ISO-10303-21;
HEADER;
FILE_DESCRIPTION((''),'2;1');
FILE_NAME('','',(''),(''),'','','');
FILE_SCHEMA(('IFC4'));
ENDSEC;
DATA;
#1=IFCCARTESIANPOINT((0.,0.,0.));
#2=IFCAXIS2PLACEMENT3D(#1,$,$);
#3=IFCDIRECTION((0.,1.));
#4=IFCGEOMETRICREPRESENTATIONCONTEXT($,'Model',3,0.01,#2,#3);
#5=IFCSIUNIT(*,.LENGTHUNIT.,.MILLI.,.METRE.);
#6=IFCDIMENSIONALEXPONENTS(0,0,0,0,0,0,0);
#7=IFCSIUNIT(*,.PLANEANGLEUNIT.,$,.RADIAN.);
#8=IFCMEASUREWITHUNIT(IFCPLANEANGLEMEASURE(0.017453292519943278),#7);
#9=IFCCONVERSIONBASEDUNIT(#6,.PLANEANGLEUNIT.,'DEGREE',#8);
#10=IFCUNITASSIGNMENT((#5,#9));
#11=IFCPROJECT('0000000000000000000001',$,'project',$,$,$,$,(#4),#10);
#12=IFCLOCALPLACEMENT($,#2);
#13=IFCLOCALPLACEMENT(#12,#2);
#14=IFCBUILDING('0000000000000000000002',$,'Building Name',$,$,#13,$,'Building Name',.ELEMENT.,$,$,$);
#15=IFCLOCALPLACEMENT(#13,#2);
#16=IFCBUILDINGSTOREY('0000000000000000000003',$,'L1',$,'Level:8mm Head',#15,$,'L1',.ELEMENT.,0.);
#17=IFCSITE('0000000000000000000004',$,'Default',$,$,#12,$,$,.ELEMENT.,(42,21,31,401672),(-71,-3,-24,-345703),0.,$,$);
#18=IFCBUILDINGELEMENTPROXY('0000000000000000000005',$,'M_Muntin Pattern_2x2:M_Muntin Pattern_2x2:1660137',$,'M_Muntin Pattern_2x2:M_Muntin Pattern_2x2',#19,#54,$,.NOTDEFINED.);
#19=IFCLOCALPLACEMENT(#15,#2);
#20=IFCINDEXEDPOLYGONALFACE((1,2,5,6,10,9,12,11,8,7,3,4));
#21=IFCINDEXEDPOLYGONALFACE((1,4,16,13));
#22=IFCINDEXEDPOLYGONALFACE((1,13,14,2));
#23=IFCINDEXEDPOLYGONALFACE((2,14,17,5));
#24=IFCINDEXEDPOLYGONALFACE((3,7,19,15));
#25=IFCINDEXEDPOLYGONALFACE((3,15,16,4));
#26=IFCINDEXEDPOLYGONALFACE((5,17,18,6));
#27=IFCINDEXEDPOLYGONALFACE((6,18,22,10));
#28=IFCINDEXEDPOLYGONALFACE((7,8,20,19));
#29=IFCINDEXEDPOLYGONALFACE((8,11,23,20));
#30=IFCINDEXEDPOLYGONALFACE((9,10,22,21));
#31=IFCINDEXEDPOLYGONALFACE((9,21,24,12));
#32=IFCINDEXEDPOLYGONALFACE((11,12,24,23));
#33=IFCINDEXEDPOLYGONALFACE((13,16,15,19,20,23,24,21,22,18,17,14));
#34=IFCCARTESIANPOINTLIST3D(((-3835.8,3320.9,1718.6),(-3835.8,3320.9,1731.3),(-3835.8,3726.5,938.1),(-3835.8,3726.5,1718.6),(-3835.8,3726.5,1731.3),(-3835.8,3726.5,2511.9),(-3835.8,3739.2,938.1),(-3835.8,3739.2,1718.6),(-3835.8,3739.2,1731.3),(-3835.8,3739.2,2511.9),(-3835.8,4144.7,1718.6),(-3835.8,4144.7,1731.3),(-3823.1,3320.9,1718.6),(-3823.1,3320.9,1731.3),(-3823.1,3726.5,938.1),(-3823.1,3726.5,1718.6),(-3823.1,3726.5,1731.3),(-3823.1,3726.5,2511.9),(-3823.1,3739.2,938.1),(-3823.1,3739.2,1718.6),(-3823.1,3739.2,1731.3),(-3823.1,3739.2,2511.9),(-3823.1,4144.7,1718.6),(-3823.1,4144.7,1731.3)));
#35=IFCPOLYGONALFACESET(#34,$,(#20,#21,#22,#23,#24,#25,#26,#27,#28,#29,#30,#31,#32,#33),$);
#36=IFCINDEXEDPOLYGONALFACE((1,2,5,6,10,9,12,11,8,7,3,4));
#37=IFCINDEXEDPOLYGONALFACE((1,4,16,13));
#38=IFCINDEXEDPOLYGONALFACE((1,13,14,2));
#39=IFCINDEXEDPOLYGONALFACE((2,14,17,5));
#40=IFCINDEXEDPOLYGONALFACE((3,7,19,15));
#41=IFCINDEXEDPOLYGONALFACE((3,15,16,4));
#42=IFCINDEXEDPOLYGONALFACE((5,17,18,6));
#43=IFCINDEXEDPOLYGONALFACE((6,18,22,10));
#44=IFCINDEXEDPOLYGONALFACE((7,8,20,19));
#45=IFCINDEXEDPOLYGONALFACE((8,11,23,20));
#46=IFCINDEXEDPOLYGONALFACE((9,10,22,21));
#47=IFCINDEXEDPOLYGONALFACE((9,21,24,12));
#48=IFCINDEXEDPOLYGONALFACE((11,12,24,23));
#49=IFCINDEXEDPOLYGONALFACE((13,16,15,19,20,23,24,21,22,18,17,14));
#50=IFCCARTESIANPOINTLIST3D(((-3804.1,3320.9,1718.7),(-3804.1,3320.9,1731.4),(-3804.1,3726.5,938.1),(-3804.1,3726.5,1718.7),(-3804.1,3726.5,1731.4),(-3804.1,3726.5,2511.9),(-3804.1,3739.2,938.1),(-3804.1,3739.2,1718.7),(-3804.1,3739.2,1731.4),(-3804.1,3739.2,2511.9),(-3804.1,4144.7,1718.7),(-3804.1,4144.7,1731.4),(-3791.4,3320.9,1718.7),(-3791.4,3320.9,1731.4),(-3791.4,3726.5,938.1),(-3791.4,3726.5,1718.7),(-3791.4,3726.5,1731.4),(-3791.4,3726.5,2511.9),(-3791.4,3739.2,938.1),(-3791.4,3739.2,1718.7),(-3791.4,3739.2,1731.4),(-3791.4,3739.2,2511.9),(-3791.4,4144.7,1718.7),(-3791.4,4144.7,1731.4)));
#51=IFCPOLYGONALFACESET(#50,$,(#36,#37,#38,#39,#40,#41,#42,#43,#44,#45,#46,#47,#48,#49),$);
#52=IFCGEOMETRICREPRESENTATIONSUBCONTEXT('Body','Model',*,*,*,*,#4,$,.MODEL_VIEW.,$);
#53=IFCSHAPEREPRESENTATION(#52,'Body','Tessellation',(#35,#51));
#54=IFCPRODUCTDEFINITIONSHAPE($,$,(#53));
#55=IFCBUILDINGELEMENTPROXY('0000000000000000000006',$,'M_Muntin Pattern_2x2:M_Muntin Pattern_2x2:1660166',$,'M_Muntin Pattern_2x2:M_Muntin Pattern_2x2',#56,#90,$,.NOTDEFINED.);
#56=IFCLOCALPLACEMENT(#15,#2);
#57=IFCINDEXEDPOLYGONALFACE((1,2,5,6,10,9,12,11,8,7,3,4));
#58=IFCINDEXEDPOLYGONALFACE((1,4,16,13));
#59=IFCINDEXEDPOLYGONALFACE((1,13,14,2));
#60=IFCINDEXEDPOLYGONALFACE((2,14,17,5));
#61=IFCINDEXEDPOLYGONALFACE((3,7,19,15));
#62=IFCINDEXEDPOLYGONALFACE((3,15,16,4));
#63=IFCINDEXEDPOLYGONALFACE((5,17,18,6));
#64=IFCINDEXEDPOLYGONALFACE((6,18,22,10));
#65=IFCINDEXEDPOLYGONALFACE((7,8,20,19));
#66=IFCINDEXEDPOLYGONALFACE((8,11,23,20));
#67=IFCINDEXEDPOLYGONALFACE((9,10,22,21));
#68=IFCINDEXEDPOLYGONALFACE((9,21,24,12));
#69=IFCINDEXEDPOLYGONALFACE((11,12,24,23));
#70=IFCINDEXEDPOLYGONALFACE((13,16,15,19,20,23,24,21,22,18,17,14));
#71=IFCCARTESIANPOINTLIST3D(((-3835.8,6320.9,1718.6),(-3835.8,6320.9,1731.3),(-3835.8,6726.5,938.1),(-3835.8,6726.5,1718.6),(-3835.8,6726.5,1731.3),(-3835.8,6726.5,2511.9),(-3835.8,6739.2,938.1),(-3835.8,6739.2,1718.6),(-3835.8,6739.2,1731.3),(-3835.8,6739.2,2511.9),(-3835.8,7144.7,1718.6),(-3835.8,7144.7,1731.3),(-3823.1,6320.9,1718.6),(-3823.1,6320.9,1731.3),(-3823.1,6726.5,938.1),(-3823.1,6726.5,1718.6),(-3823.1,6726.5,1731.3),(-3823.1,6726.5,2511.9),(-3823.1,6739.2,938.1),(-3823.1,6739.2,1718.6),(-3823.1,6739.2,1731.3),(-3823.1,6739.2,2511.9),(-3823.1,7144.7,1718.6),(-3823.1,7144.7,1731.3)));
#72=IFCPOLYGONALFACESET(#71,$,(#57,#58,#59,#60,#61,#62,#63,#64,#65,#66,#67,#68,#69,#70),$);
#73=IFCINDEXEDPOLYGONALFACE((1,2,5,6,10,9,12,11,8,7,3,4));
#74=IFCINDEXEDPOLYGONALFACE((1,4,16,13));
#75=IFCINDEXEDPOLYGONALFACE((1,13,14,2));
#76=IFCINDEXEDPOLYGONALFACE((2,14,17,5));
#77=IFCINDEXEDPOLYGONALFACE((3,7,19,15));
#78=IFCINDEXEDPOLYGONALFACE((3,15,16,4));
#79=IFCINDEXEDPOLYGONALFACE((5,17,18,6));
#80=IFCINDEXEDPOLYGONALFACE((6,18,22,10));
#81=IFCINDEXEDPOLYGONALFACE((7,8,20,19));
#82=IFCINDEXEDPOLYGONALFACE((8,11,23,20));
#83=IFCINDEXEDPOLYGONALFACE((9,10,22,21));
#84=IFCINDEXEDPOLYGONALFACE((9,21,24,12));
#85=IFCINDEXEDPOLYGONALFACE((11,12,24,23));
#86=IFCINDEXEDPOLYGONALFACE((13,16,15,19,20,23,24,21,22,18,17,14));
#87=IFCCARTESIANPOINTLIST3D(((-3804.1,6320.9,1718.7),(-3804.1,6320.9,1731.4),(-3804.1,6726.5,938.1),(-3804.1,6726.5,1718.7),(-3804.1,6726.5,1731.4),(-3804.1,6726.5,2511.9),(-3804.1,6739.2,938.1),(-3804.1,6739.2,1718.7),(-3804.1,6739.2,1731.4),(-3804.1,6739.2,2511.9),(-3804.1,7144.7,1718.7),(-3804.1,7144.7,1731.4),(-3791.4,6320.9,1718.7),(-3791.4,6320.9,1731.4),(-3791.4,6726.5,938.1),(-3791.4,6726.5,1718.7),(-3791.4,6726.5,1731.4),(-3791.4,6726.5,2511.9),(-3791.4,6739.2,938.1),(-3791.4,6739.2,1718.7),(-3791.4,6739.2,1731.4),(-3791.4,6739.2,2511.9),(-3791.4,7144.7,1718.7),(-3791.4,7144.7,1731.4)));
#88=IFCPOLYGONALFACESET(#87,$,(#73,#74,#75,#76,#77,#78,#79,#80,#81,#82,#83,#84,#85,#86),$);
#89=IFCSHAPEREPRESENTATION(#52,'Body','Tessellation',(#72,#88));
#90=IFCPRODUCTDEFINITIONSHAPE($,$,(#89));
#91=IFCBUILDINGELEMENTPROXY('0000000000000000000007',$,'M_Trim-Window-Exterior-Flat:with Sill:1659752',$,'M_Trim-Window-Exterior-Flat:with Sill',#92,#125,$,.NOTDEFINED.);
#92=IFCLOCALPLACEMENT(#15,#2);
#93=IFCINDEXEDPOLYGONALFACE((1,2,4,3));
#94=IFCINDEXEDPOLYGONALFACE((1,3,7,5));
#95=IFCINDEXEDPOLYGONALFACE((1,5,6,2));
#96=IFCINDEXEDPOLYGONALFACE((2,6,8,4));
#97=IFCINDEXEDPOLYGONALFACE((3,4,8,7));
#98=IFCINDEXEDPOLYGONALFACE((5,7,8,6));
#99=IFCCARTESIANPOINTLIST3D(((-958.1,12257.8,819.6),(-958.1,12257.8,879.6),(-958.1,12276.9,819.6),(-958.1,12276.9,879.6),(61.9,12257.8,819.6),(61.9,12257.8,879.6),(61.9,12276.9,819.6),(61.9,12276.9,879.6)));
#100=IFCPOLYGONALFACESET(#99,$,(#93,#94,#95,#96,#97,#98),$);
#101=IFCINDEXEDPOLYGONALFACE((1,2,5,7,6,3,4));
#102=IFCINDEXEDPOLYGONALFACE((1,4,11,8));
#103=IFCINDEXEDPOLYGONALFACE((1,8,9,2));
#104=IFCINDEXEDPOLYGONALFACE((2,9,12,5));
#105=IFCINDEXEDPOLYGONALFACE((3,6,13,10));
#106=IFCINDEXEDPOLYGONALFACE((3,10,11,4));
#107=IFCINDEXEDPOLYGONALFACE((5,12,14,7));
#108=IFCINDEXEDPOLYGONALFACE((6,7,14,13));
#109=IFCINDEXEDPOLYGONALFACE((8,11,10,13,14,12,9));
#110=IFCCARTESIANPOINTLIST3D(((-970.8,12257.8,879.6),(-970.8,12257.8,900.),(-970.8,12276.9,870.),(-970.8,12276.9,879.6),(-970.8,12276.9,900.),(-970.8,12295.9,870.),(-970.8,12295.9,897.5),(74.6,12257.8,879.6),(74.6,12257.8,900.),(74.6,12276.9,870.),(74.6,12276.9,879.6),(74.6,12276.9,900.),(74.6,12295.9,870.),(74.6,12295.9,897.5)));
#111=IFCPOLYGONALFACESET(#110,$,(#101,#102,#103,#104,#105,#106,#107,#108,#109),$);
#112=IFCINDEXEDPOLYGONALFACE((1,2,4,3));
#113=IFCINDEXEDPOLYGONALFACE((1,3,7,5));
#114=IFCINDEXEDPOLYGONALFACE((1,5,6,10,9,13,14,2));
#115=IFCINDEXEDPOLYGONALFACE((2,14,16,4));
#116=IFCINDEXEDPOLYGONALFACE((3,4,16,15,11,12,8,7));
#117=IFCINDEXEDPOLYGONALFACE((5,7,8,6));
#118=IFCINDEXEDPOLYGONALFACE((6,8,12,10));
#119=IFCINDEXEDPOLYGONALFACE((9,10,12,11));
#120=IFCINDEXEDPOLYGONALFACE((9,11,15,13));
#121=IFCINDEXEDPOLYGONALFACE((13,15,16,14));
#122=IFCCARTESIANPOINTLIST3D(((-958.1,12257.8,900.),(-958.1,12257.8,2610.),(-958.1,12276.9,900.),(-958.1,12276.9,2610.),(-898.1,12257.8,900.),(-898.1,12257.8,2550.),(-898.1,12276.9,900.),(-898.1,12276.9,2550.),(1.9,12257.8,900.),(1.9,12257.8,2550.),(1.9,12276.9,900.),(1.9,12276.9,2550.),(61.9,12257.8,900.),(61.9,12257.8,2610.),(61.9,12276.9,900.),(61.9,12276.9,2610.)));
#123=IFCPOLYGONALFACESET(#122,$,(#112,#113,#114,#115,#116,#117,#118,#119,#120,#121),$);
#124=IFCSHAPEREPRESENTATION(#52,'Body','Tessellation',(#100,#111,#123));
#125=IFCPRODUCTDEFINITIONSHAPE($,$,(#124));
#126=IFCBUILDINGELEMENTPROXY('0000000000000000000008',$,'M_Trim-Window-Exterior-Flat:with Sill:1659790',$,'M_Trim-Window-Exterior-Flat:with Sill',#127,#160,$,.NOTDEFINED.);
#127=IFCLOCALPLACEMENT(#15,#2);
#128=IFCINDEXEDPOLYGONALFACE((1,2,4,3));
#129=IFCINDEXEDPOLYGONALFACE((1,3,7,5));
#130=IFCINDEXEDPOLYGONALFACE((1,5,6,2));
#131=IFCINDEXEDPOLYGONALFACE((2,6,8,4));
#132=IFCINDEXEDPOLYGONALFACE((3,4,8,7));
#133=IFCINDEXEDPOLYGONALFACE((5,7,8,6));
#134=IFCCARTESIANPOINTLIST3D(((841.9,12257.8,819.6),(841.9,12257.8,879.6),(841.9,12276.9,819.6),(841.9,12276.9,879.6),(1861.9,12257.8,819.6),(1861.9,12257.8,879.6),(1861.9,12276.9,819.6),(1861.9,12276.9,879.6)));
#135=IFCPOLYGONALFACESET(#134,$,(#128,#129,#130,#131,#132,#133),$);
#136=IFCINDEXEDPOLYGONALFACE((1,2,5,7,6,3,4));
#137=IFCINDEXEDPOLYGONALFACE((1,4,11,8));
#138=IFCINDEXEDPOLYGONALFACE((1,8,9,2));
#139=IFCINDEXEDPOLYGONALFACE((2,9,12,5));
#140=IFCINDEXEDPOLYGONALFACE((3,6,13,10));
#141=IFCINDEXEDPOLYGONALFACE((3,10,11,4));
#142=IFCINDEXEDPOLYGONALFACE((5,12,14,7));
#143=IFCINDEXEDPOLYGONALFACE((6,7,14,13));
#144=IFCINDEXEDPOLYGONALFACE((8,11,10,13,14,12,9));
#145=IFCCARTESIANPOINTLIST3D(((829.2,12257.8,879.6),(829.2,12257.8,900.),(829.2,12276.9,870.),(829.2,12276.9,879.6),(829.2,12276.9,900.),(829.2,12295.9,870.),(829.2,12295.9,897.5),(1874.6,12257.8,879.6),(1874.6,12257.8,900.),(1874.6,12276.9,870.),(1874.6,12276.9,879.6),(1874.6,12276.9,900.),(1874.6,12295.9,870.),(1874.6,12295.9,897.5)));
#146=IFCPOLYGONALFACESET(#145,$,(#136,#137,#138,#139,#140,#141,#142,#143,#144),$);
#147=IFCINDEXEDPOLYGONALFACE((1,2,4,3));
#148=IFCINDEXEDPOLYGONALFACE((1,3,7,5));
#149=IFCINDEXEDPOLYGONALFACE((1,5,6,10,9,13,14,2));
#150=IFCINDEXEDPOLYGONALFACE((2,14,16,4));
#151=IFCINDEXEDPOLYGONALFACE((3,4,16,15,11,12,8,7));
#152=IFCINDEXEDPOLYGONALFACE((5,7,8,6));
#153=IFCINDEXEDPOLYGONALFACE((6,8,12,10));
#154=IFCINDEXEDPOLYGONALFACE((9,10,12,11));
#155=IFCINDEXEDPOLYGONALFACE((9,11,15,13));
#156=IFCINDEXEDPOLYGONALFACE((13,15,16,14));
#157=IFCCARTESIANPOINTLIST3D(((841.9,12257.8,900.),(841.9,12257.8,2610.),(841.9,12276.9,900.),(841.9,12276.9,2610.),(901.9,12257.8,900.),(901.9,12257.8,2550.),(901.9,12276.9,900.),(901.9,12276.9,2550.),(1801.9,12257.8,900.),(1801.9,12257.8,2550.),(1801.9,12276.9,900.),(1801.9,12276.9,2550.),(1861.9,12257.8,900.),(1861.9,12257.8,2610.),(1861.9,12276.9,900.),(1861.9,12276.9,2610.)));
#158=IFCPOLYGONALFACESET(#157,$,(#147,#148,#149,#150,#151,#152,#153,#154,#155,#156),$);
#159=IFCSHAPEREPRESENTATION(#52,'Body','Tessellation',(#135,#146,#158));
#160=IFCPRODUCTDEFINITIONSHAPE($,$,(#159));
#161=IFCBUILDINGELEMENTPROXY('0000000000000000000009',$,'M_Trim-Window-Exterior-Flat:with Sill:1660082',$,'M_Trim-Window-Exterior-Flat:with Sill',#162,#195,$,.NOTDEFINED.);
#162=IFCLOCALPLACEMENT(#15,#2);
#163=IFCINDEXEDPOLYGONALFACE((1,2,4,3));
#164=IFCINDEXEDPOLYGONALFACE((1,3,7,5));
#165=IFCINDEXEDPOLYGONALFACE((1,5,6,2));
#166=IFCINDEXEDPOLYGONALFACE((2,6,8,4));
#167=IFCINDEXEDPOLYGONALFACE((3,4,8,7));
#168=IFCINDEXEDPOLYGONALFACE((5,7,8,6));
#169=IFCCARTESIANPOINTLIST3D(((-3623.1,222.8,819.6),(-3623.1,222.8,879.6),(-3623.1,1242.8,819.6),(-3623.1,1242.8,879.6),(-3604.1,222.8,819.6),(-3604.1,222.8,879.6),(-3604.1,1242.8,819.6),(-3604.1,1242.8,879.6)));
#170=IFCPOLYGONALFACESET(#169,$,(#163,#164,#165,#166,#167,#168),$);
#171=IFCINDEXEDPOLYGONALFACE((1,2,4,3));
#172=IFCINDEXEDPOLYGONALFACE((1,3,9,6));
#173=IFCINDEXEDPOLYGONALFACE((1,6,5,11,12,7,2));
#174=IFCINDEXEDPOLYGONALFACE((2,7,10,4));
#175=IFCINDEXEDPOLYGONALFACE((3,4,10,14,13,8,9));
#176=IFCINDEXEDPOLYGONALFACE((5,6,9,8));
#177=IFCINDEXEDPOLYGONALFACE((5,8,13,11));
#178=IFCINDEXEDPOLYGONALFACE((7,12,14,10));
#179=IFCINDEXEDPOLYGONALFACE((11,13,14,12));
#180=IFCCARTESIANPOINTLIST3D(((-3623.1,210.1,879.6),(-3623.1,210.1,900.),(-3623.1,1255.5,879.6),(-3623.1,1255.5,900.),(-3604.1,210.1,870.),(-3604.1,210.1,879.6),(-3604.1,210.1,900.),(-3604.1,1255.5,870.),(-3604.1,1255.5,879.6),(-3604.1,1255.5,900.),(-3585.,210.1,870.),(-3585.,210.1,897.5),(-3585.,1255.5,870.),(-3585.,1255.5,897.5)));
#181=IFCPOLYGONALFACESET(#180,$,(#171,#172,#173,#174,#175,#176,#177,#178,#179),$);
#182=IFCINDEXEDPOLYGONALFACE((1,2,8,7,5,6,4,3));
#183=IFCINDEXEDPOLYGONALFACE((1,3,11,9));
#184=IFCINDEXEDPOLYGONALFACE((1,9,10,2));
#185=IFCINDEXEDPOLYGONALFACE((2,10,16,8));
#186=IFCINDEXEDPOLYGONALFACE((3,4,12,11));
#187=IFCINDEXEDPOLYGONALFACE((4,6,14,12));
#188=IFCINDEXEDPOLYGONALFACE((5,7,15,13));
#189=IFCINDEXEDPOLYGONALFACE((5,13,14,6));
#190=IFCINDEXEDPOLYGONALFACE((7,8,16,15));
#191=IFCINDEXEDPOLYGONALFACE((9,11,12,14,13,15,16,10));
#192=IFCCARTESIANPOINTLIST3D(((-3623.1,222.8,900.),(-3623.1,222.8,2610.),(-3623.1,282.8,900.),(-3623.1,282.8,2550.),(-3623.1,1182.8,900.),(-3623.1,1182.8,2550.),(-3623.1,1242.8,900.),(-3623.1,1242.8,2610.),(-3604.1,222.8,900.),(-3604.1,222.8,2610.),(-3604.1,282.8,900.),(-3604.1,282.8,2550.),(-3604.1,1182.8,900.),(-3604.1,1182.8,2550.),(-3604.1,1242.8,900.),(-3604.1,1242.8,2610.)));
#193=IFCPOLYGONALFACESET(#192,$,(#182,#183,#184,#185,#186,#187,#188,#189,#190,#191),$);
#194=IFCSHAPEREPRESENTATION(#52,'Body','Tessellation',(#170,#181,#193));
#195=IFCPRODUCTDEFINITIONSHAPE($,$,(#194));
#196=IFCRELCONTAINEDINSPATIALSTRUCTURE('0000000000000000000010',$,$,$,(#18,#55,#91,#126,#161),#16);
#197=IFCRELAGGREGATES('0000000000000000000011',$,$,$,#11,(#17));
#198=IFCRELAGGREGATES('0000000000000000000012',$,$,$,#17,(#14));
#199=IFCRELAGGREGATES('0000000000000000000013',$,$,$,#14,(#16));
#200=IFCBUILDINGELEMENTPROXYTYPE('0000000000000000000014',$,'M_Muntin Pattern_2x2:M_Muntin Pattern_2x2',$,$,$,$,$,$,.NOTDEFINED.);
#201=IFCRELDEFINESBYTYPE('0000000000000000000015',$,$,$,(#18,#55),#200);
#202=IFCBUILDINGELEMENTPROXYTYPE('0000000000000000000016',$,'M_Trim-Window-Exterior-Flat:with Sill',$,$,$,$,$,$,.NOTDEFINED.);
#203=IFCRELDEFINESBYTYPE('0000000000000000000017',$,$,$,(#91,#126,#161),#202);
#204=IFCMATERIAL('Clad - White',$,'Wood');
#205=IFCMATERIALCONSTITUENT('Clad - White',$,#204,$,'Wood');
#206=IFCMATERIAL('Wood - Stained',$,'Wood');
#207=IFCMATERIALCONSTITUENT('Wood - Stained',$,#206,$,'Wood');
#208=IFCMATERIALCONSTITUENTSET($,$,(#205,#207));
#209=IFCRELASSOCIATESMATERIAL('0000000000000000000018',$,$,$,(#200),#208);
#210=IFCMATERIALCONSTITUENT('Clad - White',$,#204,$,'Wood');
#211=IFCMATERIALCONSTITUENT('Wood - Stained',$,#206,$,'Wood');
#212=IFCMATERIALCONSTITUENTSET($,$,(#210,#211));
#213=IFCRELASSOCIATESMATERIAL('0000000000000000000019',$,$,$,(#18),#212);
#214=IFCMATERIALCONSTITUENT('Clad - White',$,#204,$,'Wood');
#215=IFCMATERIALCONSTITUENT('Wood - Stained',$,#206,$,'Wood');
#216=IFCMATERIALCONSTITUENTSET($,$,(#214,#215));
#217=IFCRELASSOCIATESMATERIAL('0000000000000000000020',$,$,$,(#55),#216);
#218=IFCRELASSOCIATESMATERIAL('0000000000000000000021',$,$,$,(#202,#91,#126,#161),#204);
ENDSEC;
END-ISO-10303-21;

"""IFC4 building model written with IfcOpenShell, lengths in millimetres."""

from ifc_helpers import new_model, entity, si_unit, converted_unit, direction, frame, origin, place, context, subcontext, project, spatial, indexed_curve, outline, extrude, source, transform, mapped, material, constituent, constituent_set, type_object, type_shapes, element, save


model = new_model("IFC4")

# Units and contexts
model_context = context("Model", 3, precision=0.01, world=origin(), true_north=direction((0.0, 1.0)))
body_context = subcontext(model_context, "Body", "Model", "MODEL_VIEW")
ifc_project = project(units=[si_unit("LENGTHUNIT", "METRE", prefix="MILLI"), converted_unit("PLANEANGLEUNIT", "DEGREE", entity("IfcPlaneAngleMeasure", 0.017453292519943278), si_unit("PLANEANGLEUNIT", "RADIAN"), dimensions=[0, 0, 0, 0, 0, 0, 0])], contexts=[model_context])

# Site, building, storey
site_placement = place(None, origin())
site = spatial("IfcSite", under=ifc_project, at=site_placement, Name="Default", CompositionType="ELEMENT", RefLatitude=(42, 21, 31, 401672), RefLongitude=(-71, -3, -24, -345703), RefElevation=0.0)
building_placement = place(site_placement, origin())
building = spatial("IfcBuilding", under=site, at=building_placement, Name="Building Name", LongName="Building Name", CompositionType="ELEMENT")
storey_placement = place(building_placement, origin())
storey = spatial("IfcBuildingStorey", under=building, at=storey_placement, Name="L1", ObjectType="Level:8mm Head", LongName="L1", CompositionType="ELEMENT", Elevation=0.0)

# Building element proxies
ifc_material_1 = material(Name="Clad - White", Category="Wood")
ifc_material_2 = material(Name="Wood - Stained", Category="Wood")
ifc_constituent_1 = constituent(ifc_material_1, Name="Clad - White", Category="Wood")
ifc_constituent_2 = constituent(ifc_material_2, Name="Wood - Stained", Category="Wood")
ifc_constituent_set_1 = constituent_set(constituents=[ifc_constituent_1, ifc_constituent_2])
building_element_proxy_type_1 = type_object("IfcBuildingElementProxyType", Name="M_Muntin Pattern_2x2:M_Muntin Pattern_2x2", PredefinedType="NOTDEFINED", material=ifc_constituent_set_1)
shared_shape_1 = source(origin(), body_context, "Body", "SweptSolid", [
    extrude(outline(indexed_curve([(6.4, -6.4), (786.9, -6.4), (786.9, 6.3), (6.4, 6.3), (6.4, 411.9), (-6.3, 411.9), (-6.3, 6.3), (-786.9, 6.3), (-786.9, -6.4), (-6.3, -6.4), (-6.3, -411.9), (6.4, -411.9), (6.4, -6.4)], self_intersect=False)), frame((0.0, -22.2, 786.9), z_axis=(0.0, 1.0, 0.0), x_axis=(0.0, 0.0, 1.0)), (0.0, 0.0, 1.0), 12.7),
    extrude(outline(indexed_curve([(6.4, -6.4), (786.9, -6.4), (786.9, 6.3), (6.4, 6.3), (6.4, 411.9), (-6.3, 411.9), (-6.3, 6.3), (-786.9, 6.3), (-786.9, -6.4), (-6.3, -6.4), (-6.3, -411.9), (6.4, -411.9), (6.4, -6.4)], self_intersect=False)), frame((0.0, 9.5, 786.9), z_axis=(0.0, 1.0, 0.0), x_axis=(0.0, 0.0, 1.0)), (0.0, 0.0, 1.0), 12.7),
])
type_shapes(building_element_proxy_type_1, [shared_shape_1])
ifc_constituent_3 = constituent(ifc_material_1, Name="Clad - White", Category="Wood")
ifc_constituent_4 = constituent(ifc_material_2, Name="Wood - Stained", Category="Wood")
ifc_constituent_set_2 = constituent_set(constituents=[ifc_constituent_3, ifc_constituent_4])
proxy_1_placement = place(storey_placement, frame((-3813.6, 3732.8, 938.1), z_axis=(0.0, 0.0, 1.0), x_axis=(0.0, -1.0, 0.0)))
element("IfcBuildingElementProxy", 1, at=proxy_1_placement, inside=storey, type_object=building_element_proxy_type_1, material=ifc_constituent_set_2, Name="M_Muntin Pattern_2x2:M_Muntin Pattern_2x2:1660137", ObjectType="M_Muntin Pattern_2x2:M_Muntin Pattern_2x2", PredefinedType="NOTDEFINED", context=body_context, shape_type="MappedRepresentation", body=[
    mapped(shared_shape_1, transform((0.0, 0.0, 0.0), scale=1.0)),
])
ifc_constituent_5 = constituent(ifc_material_1, Name="Clad - White", Category="Wood")
ifc_constituent_6 = constituent(ifc_material_2, Name="Wood - Stained", Category="Wood")
ifc_constituent_set_3 = constituent_set(constituents=[ifc_constituent_5, ifc_constituent_6])
proxy_2_placement = place(storey_placement, frame((-3813.6, 6732.8, 938.1), z_axis=(0.0, 0.0, 1.0), x_axis=(0.0, -1.0, 0.0)))
element("IfcBuildingElementProxy", 2, at=proxy_2_placement, inside=storey, type_object=building_element_proxy_type_1, material=ifc_constituent_set_3, Name="M_Muntin Pattern_2x2:M_Muntin Pattern_2x2:1660166", ObjectType="M_Muntin Pattern_2x2:M_Muntin Pattern_2x2", PredefinedType="NOTDEFINED", context=body_context, shape_type="MappedRepresentation", body=[
    mapped(shared_shape_1, transform((0.0, 0.0, 0.0), scale=1.0)),
])
building_element_proxy_type_2 = type_object("IfcBuildingElementProxyType", Name="M_Trim-Window-Exterior-Flat:with Sill", PredefinedType="NOTDEFINED", material=ifc_material_1)
shared_shape_2 = source(origin(), body_context, "Body", "SweptSolid", [
    extrude(outline(indexed_curve([(-510.0, -30.0), (510.0, -30.0), (510.0, 30.0), (-510.0, 30.0), (-510.0, -30.0)], self_intersect=False)), frame((0.0, -1700.4, 0.0), z_axis=(0.0, 0.0, 1.0), x_axis=(-1.0, 0.0, 0.0)), (0.0, 0.0, 1.0), 19.0),
    extrude(outline(indexed_curve([(-19.0, -15.2), (0.0, -15.2), (0.0, -5.7), (19.0, -5.7), (19.0, 14.8), (0.0, 14.8), (-19.0, 12.3), (-19.0, -15.2)], self_intersect=False)), frame((-522.7, -1664.8, 19.0), z_axis=(1.0, 0.0, 0.0), x_axis=(0.0, 0.0, -1.0)), (0.0, 0.0, 1.0), 1045.4),
    extrude(outline(indexed_curve([(-870.0, -510.0), (840.0, -510.0), (840.0, -450.0), (-810.0, -450.0), (-810.0, 450.0), (840.0, 450.0), (840.0, 510.0), (-870.0, 510.0), (-870.0, -510.0)], self_intersect=False)), frame((0.0, -810.0, 0.0), z_axis=(0.0, 0.0, 1.0), x_axis=(0.0, -1.0, 0.0)), (0.0, 0.0, 1.0), 19.0),
])
type_shapes(building_element_proxy_type_2, [shared_shape_2])
for number, where, z_axis, x_axis, name in (
    (3, (-448.1, 12257.8, 2550.0), (0.0, 1.0, 0.0), (-1.0, 0.0, 0.0), "M_Trim-Window-Exterior-Flat:with Sill:1659752"),
    (4, (1351.9, 12257.8, 2550.0), (0.0, 1.0, 0.0), (-1.0, 0.0, 0.0), "M_Trim-Window-Exterior-Flat:with Sill:1659790"),
    (5, (-3623.1, 732.8, 2550.0), (1.0, 0.0, 0.0), (0.0, 1.0, 0.0), "M_Trim-Window-Exterior-Flat:with Sill:1660082"),
):
    element("IfcBuildingElementProxy", number, at=place(storey_placement, frame(where, z_axis=z_axis, x_axis=x_axis)), inside=storey, type_object=building_element_proxy_type_2, material=ifc_material_1, Name=name, ObjectType="M_Trim-Window-Exterior-Flat:with Sill", PredefinedType="NOTDEFINED", context=body_context, shape_type="MappedRepresentation", body=[
        mapped(shared_shape_2, transform((0.0, 0.0, 0.0), scale=1.0)),
    ])

save(model, "model.ifc")
